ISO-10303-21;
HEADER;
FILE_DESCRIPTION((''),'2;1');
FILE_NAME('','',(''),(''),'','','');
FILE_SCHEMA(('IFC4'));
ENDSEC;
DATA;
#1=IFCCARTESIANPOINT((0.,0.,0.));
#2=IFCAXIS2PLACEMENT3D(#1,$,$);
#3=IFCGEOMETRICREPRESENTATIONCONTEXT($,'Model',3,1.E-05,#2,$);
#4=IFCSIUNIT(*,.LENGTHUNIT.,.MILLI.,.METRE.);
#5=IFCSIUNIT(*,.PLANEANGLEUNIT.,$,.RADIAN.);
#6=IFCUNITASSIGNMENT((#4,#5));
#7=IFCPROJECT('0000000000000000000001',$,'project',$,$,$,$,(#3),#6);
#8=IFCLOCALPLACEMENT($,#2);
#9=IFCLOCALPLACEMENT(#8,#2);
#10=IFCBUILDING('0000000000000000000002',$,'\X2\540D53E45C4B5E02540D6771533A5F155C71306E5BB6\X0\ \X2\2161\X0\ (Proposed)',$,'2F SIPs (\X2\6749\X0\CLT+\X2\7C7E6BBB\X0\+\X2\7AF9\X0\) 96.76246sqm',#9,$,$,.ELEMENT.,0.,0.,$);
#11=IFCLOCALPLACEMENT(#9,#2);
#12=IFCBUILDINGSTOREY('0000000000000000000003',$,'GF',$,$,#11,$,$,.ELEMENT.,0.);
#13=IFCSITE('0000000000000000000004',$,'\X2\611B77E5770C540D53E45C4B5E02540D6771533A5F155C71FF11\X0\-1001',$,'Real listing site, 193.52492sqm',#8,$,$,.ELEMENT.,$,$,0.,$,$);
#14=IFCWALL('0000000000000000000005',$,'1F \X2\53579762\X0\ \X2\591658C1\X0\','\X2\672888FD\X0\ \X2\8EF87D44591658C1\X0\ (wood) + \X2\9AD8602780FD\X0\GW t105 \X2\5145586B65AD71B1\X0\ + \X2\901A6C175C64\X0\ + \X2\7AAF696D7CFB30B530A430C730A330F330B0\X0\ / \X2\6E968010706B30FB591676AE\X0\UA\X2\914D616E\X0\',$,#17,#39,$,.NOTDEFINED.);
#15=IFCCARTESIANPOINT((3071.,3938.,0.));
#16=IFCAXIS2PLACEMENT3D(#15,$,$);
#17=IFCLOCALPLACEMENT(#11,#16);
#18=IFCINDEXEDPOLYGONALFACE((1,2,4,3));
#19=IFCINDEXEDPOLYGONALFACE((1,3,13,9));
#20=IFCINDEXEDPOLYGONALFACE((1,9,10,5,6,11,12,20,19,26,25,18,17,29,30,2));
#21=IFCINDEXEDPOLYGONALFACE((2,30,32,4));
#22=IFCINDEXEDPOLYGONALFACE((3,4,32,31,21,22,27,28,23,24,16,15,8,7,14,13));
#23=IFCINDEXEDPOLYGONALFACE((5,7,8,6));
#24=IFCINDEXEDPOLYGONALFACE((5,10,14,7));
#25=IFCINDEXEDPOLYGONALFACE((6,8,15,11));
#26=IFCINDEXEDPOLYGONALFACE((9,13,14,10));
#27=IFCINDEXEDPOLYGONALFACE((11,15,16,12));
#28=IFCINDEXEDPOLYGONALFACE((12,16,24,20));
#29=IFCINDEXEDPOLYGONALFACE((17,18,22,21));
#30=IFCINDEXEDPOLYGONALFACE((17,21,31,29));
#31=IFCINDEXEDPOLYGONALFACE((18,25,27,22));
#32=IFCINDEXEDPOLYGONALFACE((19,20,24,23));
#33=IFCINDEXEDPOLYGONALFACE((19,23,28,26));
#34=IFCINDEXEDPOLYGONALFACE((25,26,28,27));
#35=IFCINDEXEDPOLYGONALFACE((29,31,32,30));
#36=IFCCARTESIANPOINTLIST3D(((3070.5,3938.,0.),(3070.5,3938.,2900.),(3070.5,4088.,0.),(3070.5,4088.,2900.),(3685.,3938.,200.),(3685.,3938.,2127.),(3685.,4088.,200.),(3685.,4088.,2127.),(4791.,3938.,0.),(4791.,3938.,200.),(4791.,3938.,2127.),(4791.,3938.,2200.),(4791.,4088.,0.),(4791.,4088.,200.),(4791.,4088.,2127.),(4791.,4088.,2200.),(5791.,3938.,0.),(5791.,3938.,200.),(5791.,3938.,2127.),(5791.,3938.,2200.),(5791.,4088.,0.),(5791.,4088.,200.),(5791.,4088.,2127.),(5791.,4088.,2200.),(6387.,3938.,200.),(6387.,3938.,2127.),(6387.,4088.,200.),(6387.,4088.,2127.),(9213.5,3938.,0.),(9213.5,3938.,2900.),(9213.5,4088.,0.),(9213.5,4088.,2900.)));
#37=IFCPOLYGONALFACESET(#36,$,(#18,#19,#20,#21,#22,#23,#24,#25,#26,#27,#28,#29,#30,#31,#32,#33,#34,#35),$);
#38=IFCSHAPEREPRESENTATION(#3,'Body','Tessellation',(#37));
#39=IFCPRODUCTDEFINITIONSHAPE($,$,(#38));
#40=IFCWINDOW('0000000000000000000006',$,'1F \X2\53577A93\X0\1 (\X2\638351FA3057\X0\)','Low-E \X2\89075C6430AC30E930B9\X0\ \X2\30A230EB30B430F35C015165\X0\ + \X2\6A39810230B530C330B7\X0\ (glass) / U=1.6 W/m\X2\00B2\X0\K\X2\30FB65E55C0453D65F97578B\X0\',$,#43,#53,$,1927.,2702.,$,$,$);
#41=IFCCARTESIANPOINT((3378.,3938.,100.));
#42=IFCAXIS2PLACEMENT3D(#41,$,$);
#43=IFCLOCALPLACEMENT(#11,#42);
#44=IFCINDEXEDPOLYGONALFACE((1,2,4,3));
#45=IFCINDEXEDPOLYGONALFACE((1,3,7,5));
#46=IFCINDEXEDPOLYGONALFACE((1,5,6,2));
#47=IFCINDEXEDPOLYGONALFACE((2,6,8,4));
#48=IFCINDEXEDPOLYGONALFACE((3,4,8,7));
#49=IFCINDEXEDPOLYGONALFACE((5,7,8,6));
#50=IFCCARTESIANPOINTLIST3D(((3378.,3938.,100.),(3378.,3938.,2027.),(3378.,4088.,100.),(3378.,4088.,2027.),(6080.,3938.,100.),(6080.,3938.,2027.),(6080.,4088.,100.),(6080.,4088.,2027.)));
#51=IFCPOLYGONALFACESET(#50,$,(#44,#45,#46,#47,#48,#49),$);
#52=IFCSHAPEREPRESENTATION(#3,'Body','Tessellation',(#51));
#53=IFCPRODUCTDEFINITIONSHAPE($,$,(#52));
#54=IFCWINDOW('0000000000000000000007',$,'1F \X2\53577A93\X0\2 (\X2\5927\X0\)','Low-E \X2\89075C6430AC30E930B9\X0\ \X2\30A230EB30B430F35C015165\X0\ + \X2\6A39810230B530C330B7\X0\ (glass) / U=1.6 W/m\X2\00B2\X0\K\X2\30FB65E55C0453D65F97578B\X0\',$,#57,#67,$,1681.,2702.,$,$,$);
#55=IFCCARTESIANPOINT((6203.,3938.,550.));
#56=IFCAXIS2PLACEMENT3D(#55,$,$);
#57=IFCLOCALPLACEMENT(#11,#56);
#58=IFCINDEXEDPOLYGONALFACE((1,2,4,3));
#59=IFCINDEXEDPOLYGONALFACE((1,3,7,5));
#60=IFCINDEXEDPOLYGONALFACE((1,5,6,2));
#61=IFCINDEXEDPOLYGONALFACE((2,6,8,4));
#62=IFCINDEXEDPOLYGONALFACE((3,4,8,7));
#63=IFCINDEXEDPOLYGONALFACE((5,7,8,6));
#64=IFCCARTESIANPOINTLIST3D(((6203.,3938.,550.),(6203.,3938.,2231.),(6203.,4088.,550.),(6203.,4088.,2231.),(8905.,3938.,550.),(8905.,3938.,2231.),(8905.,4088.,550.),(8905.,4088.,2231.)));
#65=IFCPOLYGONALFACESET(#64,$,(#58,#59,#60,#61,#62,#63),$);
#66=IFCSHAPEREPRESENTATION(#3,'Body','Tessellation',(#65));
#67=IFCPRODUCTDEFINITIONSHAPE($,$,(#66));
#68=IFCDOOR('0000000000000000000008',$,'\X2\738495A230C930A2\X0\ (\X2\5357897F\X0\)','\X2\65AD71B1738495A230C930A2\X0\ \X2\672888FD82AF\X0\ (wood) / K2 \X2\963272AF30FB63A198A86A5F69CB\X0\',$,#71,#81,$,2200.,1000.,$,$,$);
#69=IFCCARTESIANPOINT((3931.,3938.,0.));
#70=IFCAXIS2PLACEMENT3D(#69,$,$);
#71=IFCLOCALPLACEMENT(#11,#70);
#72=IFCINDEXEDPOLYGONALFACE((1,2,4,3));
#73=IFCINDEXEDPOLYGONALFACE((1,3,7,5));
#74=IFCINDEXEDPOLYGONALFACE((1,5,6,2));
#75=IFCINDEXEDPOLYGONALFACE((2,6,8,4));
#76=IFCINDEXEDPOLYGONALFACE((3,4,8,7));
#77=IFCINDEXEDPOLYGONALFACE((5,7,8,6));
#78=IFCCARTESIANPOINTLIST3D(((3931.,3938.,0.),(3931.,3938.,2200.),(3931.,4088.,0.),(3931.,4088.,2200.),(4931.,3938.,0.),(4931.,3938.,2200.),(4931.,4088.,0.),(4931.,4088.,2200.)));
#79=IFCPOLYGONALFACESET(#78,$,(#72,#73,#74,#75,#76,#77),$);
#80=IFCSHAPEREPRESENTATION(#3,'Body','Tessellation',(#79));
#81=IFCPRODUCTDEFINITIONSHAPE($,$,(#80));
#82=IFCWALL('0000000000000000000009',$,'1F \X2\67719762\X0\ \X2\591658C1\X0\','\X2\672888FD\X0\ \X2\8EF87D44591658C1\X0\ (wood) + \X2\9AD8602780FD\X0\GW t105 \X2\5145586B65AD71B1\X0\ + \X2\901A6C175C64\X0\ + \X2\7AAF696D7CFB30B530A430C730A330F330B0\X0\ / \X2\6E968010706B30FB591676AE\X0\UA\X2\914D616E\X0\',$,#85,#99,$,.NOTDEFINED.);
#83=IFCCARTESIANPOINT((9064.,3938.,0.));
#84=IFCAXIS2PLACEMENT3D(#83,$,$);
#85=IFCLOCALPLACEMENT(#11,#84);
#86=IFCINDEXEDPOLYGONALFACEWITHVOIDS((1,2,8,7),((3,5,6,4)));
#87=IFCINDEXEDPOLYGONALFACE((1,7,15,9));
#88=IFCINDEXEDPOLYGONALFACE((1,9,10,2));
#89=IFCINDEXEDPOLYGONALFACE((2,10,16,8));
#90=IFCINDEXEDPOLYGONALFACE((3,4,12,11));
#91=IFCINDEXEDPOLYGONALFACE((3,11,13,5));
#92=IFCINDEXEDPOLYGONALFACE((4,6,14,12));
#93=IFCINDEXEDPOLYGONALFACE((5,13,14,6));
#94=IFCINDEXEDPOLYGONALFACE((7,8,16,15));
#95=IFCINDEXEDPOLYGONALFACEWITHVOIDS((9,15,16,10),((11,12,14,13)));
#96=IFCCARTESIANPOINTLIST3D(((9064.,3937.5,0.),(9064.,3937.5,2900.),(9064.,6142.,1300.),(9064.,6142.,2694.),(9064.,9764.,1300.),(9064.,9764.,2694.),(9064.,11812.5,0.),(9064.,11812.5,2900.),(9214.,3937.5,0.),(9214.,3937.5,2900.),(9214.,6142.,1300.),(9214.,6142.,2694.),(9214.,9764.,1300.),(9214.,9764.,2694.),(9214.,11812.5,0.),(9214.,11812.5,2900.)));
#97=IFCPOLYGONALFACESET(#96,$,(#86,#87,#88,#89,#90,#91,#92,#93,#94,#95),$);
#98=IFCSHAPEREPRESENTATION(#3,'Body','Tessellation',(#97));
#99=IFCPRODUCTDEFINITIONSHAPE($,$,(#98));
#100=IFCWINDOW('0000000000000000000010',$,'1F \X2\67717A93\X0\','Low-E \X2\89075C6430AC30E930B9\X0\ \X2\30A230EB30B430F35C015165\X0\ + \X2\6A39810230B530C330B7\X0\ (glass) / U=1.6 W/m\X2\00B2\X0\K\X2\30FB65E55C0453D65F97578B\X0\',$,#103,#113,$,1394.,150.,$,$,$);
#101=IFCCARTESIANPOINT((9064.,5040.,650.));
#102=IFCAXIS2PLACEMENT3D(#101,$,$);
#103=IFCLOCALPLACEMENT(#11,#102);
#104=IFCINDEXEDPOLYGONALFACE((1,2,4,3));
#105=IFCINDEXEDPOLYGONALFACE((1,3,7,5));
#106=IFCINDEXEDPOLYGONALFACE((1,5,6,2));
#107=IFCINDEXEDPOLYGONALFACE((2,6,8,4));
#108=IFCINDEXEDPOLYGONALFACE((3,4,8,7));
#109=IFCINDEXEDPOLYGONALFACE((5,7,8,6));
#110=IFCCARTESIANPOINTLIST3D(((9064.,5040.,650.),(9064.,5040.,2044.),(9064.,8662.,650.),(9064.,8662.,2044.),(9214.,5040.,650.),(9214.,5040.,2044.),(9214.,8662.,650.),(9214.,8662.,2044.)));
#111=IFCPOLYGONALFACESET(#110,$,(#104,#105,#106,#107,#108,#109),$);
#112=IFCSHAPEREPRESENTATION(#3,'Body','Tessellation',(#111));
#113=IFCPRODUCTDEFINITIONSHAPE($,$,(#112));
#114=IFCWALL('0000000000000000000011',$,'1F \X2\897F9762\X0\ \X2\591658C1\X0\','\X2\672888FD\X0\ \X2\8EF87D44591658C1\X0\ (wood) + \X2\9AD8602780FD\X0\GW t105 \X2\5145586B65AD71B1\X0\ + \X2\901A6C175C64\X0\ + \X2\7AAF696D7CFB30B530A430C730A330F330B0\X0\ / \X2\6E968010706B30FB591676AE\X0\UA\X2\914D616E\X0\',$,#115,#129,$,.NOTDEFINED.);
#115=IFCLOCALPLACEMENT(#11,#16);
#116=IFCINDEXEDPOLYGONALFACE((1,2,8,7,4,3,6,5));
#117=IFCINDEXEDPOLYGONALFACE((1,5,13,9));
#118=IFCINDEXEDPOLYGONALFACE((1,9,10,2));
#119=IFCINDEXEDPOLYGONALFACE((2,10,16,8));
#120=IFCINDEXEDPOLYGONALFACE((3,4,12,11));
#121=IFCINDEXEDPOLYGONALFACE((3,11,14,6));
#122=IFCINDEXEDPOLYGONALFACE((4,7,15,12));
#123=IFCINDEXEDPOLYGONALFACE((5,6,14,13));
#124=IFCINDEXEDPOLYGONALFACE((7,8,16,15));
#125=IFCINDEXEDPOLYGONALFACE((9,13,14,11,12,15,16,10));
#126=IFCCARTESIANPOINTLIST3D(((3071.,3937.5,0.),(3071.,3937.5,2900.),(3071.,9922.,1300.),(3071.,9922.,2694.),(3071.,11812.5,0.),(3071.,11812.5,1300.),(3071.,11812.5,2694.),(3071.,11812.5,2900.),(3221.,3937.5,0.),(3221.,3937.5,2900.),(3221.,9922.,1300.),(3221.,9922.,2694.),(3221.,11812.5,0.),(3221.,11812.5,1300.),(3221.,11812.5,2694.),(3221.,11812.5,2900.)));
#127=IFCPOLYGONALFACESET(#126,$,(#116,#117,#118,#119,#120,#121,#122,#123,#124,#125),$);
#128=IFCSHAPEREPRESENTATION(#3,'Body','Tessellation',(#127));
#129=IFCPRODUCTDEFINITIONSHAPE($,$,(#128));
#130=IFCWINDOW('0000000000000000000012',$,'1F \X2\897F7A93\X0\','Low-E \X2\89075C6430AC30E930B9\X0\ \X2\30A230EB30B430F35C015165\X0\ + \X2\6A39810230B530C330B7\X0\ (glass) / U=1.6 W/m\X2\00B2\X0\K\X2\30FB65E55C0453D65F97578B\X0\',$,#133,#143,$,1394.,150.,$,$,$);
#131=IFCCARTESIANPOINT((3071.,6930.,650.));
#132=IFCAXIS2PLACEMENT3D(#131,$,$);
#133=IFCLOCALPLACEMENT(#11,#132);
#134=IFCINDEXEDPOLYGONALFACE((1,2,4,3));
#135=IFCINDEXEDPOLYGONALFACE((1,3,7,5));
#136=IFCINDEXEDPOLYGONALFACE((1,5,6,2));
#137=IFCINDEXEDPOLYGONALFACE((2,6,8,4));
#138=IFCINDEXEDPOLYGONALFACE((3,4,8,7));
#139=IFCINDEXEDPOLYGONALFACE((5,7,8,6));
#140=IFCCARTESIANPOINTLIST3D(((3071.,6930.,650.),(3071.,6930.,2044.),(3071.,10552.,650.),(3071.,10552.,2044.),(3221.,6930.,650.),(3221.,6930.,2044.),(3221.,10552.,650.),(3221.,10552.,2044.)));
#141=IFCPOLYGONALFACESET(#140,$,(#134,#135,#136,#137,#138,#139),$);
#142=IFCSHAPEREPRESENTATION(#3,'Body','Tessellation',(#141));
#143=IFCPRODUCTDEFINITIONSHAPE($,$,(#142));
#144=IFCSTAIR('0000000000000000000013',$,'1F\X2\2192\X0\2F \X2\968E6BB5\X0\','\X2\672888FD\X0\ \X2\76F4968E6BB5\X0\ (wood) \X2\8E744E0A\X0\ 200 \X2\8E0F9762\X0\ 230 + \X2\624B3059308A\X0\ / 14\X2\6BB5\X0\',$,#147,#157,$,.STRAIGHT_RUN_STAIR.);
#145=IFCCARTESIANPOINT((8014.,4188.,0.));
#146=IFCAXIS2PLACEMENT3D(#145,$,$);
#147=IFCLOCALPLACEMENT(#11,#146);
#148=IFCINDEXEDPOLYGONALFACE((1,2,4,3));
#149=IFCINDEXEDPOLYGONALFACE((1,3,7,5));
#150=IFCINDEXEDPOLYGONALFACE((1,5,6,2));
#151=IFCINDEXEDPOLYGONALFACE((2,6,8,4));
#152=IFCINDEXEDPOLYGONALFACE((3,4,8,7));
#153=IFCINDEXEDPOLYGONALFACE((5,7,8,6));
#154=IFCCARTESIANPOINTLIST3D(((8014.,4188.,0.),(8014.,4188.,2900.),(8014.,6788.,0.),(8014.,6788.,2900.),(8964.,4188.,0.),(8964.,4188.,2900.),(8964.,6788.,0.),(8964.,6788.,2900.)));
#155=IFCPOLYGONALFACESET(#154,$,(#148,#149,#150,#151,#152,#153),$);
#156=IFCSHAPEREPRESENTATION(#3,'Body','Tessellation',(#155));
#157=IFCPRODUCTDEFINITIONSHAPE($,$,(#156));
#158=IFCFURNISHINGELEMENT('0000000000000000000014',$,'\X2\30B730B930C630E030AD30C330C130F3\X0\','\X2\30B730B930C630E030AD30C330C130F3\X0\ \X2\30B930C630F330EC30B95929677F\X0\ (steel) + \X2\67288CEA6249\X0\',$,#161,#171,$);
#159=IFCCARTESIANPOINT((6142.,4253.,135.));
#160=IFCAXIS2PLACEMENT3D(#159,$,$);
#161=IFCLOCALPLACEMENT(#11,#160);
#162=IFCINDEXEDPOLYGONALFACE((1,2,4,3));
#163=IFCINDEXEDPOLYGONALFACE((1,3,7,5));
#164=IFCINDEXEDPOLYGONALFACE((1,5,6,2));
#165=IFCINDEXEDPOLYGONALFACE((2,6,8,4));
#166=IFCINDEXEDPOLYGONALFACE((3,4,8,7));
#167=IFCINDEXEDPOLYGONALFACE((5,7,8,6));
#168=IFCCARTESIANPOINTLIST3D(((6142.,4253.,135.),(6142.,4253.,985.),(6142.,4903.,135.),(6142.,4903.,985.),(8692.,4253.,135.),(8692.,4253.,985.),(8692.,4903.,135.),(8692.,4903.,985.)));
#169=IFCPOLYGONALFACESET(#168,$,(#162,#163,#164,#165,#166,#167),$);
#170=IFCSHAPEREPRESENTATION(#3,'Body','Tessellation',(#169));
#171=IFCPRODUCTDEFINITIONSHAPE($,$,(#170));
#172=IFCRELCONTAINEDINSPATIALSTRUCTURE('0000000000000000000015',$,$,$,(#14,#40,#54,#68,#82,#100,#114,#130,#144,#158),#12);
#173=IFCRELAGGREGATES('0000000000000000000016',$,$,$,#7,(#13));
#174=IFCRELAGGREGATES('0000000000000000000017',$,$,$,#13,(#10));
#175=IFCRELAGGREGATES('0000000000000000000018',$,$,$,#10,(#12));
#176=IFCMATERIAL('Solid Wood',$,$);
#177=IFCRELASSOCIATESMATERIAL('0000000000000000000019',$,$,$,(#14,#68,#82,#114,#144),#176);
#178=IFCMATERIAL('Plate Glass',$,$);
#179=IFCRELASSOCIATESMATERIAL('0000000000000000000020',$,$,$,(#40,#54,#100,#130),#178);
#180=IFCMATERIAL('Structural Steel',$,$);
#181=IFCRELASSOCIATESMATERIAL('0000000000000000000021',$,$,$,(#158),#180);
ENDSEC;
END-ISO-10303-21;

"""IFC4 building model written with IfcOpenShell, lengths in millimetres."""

from ifc_helpers import new_model, si_unit, frame, frame_2d, origin, place, context, project, spatial, rectangle, extrude, material, element, fill, save


model = new_model("IFC4")

# Units and contexts
model_context = context("Model", 3, precision=1e-05, world=origin())
ifc_project = project(units=[si_unit("LENGTHUNIT", "METRE", prefix="MILLI"), si_unit("PLANEANGLEUNIT", "RADIAN")], contexts=[model_context])

# Site, building, storey
site_placement = place(None, origin())
site = spatial("IfcSite", under=ifc_project, at=site_placement, Name="愛知県名古屋市名東区引山１-1001", ObjectType="Real listing site, 193.52492sqm", CompositionType="ELEMENT", RefElevation=0.0)
building_placement = place(site_placement, origin())
building = spatial("IfcBuilding", under=site, at=building_placement, Name="名古屋市名東区引山の家 Ⅱ (Proposed)", ObjectType="2F SIPs (杉CLT+籾殻+竹) 96.76246sqm", CompositionType="ELEMENT", ElevationOfRefHeight=0.0, ElevationOfTerrain=0.0)
storey_placement = place(building_placement, origin())
storey = spatial("IfcBuildingStorey", under=building, at=storey_placement, Name="GF", CompositionType="ELEMENT", Elevation=0.0)

# Shared definitions
ifc_material_1 = material(Name="Solid Wood")

# Wall, openings, windows, door
wall_1_placement = place(storey_placement, frame((3071.0, 3938.0, 0.0)))
wall_1 = element("IfcWall", 1, at=wall_1_placement, inside=storey, material=ifc_material_1, Name="1F 南面 外壁", Description="木製 軸組外壁 (wood) + 高性能GW t105 充填断熱 + 通気層 + 窯業系サイディング / 準耐火・外皮UA配慮", PredefinedType="NOTDEFINED", context=model_context, shape_type="SweptSolid", body=[
    extrude(rectangle(XDim=6143.0, YDim=150.0, at=frame_2d((3071.0, 75.0))), frame((3071.0, 3938.0, 0.0)), (0.0, 0.0, 1.0), 2900.0),
])
opening_1_placement = place(storey_placement, frame((3378.0, 3938.0, 100.0)))
opening_1 = element("IfcOpeningElement", 2, at=opening_1_placement, cuts=wall_1, PredefinedType="NOTDEFINED", context=model_context, shape_type="SweptSolid", body=[
    extrude(rectangle(XDim=2702.0, YDim=150.0, at=frame_2d((1351.0, 75.0))), frame((3378.0, 3938.0, 100.0)), (0.0, 0.0, 1.0), 1927.0),
])
opening_2_placement = place(storey_placement, frame((6203.0, 3938.0, 550.0)))
opening_2 = element("IfcOpeningElement", 3, at=opening_2_placement, cuts=wall_1, PredefinedType="NOTDEFINED", context=model_context, shape_type="SweptSolid", body=[
    extrude(rectangle(XDim=2702.0, YDim=150.0, at=frame_2d((1351.0, 75.0))), frame((6203.0, 3938.0, 550.0)), (0.0, 0.0, 1.0), 1681.0),
])
opening_3_placement = place(storey_placement, frame((3931.0, 3938.0, 0.0)))
opening_3 = element("IfcOpeningElement", 4, at=opening_3_placement, cuts=wall_1, PredefinedType="NOTDEFINED", context=model_context, shape_type="SweptSolid", body=[
    extrude(rectangle(XDim=1000.0, YDim=150.0, at=frame_2d((500.0, 75.0))), frame((3931.0, 3938.0, 0.0)), (0.0, 0.0, 1.0), 2200.0),
])
ifc_material_2 = material(Name="Plate Glass")
window_1_placement = place(storey_placement, frame((3378.0, 3938.0, 100.0)))
window_1 = element("IfcWindow", 5, at=window_1_placement, inside=storey, material=ifc_material_2, Name="1F 南窓1 (掃出し)", Description="Low-E 複層ガラス アルゴン封入 + 樹脂サッシ (glass) / U=1.6 W/m²K・日射取得型", OverallHeight=1927.0, OverallWidth=2702.0, context=model_context, shape_type="SweptSolid", body=[
    extrude(rectangle(XDim=2702.0, YDim=150.0, at=frame_2d((1351.0, 75.0))), frame((3378.0, 3938.0, 100.0)), (0.0, 0.0, 1.0), 1927.0),
])
fill(opening_1, window_1)
window_2_placement = place(storey_placement, frame((6203.0, 3938.0, 550.0)))
window_2 = element("IfcWindow", 6, at=window_2_placement, inside=storey, material=ifc_material_2, Name="1F 南窓2 (大)", Description="Low-E 複層ガラス アルゴン封入 + 樹脂サッシ (glass) / U=1.6 W/m²K・日射取得型", OverallHeight=1681.0, OverallWidth=2702.0, context=model_context, shape_type="SweptSolid", body=[
    extrude(rectangle(XDim=2702.0, YDim=150.0, at=frame_2d((1351.0, 75.0))), frame((6203.0, 3938.0, 550.0)), (0.0, 0.0, 1.0), 1681.0),
])
fill(opening_2, window_2)
door_placement = place(storey_placement, frame((3931.0, 3938.0, 0.0)))
door = element("IfcDoor", 7, at=door_placement, inside=storey, material=ifc_material_1, Name="玄関ドア (南西)", Description="断熱玄関ドア 木製芯 (wood) / K2 防犯・採風機構", OverallHeight=2200.0, OverallWidth=1000.0, context=model_context, shape_type="SweptSolid", body=[
    extrude(rectangle(XDim=1000.0, YDim=150.0, at=frame_2d((500.0, 75.0))), frame((3931.0, 3938.0, 0.0)), (0.0, 0.0, 1.0), 2200.0),
])
fill(opening_3, door)

# Walls, openings, windows
wall_2_placement = place(storey_placement, frame((9064.0, 3938.0, 0.0)))
wall_2 = element("IfcWall", 8, at=wall_2_placement, inside=storey, material=ifc_material_1, Name="1F 東面 外壁", Description="木製 軸組外壁 (wood) + 高性能GW t105 充填断熱 + 通気層 + 窯業系サイディング / 準耐火・外皮UA配慮", PredefinedType="NOTDEFINED", context=model_context, shape_type="SweptSolid", body=[
    extrude(rectangle(XDim=150.0, YDim=7875.0, at=frame_2d((75.0, 3937.0))), frame((9064.0, 3938.0, 0.0)), (0.0, 0.0, 1.0), 2900.0),
])
opening_4_placement = place(storey_placement, frame((9064.0, 5040.0, 650.0)))
opening_4 = element("IfcOpeningElement", 9, at=opening_4_placement, cuts=wall_2, PredefinedType="NOTDEFINED", context=model_context, shape_type="SweptSolid", body=[
    extrude(rectangle(XDim=150.0, YDim=3622.0, at=frame_2d((75.0, 1811.0))), frame((9064.0, 5040.0, 650.0)), (0.0, 0.0, 1.0), 1394.0),
])
window_3_placement = place(storey_placement, frame((9064.0, 5040.0, 650.0)))
window_3 = element("IfcWindow", 10, at=window_3_placement, inside=storey, material=ifc_material_2, Name="1F 東窓", Description="Low-E 複層ガラス アルゴン封入 + 樹脂サッシ (glass) / U=1.6 W/m²K・日射取得型", OverallHeight=1394.0, OverallWidth=150.0, context=model_context, shape_type="SweptSolid", body=[
    extrude(rectangle(XDim=150.0, YDim=3622.0, at=frame_2d((75.0, 1811.0))), frame((9064.0, 5040.0, 650.0)), (0.0, 0.0, 1.0), 1394.0),
])
fill(opening_4, window_3)
wall_3_placement = place(storey_placement, frame((3071.0, 3938.0, 0.0)))
wall_3 = element("IfcWall", 11, at=wall_3_placement, inside=storey, material=ifc_material_1, Name="1F 西面 外壁", Description="木製 軸組外壁 (wood) + 高性能GW t105 充填断熱 + 通気層 + 窯業系サイディング / 準耐火・外皮UA配慮", PredefinedType="NOTDEFINED", context=model_context, shape_type="SweptSolid", body=[
    extrude(rectangle(XDim=150.0, YDim=7875.0, at=frame_2d((75.0, 3937.0))), frame((3071.0, 3938.0, 0.0)), (0.0, 0.0, 1.0), 2900.0),
])
opening_5_placement = place(storey_placement, frame((3071.0, 6930.0, 650.0)))
opening_5 = element("IfcOpeningElement", 12, at=opening_5_placement, cuts=wall_3, PredefinedType="NOTDEFINED", context=model_context, shape_type="SweptSolid", body=[
    extrude(rectangle(XDim=150.0, YDim=3622.0, at=frame_2d((75.0, 1811.0))), frame((3071.0, 6930.0, 650.0)), (0.0, 0.0, 1.0), 1394.0),
])
window_4_placement = place(storey_placement, frame((3071.0, 6930.0, 650.0)))
window_4 = element("IfcWindow", 13, at=window_4_placement, inside=storey, material=ifc_material_2, Name="1F 西窓", Description="Low-E 複層ガラス アルゴン封入 + 樹脂サッシ (glass) / U=1.6 W/m²K・日射取得型", OverallHeight=1394.0, OverallWidth=150.0, context=model_context, shape_type="SweptSolid", body=[
    extrude(rectangle(XDim=150.0, YDim=3622.0, at=frame_2d((75.0, 1811.0))), frame((3071.0, 6930.0, 650.0)), (0.0, 0.0, 1.0), 1394.0),
])
fill(opening_5, window_4)

# Stair
stair_placement = place(storey_placement, frame((8014.0, 4188.0, 0.0)))
element("IfcStair", 14, at=stair_placement, inside=storey, material=ifc_material_1, Name="1F→2F 階段", Description="木製 直階段 (wood) 蹴上 200 踏面 230 + 手すり / 14段", PredefinedType="STRAIGHT_RUN_STAIR", context=model_context, shape_type="SweptSolid", body=[
    extrude(rectangle(XDim=950.0, YDim=2600.0, at=frame_2d((475.0, 1300.0))), frame((8014.0, 4188.0, 0.0)), (0.0, 0.0, 1.0), 2900.0),
])

# Furnishing element
ifc_material_3 = material(Name="Structural Steel")
furnishing_placement = place(storey_placement, frame((6142.0, 4253.0, 135.0)))
element("IfcFurnishingElement", 15, at=furnishing_placement, inside=storey, material=ifc_material_3, Name="システムキッチン", Description="システムキッチン ステンレス天板 (steel) + 木質扉", context=model_context, shape_type="SweptSolid", body=[
    extrude(rectangle(XDim=2550.0, YDim=650.0, at=frame_2d((1275.0, 325.0))), frame((6142.0, 4253.0, 135.0)), (0.0, 0.0, 1.0), 850.0),
])

save(model, "model.ifc")
